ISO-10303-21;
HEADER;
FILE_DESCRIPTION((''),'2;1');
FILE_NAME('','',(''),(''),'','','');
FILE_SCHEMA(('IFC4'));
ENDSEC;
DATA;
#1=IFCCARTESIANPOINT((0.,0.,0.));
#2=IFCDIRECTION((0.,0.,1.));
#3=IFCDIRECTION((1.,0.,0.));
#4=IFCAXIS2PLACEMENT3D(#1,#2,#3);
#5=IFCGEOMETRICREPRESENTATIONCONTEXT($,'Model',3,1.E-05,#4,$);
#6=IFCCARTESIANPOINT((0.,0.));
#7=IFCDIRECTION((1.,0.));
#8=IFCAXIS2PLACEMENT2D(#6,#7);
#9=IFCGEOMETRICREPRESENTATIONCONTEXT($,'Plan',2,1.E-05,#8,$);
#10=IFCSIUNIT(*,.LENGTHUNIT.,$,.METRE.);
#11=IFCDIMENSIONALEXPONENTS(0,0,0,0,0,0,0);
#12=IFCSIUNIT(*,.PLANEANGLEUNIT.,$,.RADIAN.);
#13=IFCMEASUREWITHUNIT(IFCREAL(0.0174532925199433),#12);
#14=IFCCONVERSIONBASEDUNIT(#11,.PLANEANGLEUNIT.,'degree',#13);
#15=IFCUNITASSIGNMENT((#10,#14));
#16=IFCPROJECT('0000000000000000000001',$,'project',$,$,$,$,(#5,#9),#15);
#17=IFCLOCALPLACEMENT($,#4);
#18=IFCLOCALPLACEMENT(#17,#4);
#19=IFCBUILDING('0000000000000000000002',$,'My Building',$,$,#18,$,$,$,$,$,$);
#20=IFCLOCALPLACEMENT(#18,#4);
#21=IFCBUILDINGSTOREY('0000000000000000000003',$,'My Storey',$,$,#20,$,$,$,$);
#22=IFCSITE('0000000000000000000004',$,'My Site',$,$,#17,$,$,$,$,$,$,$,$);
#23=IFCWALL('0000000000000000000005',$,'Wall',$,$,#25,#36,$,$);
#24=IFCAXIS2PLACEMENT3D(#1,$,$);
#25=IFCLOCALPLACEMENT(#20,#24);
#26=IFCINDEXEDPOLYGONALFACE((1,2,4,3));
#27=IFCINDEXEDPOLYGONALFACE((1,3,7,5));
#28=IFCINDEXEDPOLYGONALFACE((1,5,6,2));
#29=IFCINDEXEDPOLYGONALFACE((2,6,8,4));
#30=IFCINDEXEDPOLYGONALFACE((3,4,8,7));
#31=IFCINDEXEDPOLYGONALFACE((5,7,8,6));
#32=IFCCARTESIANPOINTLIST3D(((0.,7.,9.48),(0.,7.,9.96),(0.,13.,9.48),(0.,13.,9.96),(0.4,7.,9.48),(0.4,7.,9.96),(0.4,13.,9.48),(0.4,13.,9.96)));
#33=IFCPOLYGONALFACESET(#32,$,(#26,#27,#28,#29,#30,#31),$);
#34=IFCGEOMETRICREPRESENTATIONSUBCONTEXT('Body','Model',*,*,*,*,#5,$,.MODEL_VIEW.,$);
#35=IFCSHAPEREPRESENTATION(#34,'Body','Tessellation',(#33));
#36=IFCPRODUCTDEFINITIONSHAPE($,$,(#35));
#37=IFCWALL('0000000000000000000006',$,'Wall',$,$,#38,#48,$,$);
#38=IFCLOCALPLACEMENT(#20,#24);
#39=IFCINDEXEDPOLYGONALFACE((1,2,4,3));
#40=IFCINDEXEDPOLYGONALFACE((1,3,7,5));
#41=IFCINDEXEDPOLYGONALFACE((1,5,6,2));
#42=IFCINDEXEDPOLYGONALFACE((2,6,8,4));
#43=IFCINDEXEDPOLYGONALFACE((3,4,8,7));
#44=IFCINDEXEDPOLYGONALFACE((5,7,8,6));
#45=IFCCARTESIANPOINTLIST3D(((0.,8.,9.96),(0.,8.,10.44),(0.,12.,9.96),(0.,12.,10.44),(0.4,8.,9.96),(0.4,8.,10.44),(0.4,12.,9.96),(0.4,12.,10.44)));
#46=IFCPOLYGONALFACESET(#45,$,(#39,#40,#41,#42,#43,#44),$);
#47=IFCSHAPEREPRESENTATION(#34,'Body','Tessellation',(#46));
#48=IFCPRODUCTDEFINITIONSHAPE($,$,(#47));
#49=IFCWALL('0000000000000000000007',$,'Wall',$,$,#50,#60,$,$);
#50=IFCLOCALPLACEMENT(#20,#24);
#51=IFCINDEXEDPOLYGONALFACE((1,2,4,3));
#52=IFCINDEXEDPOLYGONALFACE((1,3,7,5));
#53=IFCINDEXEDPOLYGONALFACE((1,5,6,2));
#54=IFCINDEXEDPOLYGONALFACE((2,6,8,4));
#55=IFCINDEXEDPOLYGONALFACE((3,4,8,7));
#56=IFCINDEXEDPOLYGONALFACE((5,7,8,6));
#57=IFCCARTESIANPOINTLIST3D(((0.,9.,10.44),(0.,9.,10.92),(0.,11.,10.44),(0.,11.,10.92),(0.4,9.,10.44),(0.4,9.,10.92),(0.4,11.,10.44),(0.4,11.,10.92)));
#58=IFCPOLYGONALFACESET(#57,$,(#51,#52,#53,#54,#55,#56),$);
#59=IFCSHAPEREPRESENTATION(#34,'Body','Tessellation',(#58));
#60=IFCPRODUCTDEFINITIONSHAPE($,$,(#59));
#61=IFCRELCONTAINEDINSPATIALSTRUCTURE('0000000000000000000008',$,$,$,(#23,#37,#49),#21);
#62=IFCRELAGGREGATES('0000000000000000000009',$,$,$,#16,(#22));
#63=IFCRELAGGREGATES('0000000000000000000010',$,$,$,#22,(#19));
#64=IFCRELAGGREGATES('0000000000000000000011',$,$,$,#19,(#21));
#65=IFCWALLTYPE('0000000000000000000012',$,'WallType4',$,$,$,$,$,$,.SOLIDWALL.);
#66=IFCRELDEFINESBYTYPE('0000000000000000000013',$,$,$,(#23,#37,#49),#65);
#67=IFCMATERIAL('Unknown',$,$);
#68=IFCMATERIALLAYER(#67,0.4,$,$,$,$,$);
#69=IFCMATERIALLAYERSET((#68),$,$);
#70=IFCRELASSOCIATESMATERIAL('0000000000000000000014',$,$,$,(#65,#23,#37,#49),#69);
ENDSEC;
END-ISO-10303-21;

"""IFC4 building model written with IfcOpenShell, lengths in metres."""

from ifc_helpers import new_model, entity, si_unit, converted_unit, frame, origin_with_axes, origin_2d_with_axis, place, context, subcontext, project, spatial, indexed_curve, outline, extrude, material, layer, layer_set, layer_usage, type_object, element, save


model = new_model("IFC4")

# Units and contexts
model_context = context("Model", 3, precision=1e-05, world=origin_with_axes())
plan_context = context("Plan", 2, precision=1e-05, world=origin_2d_with_axis())
body_context_1 = subcontext(model_context, "Body", "Model", "MODEL_VIEW")
ifc_project = project(units=[si_unit("LENGTHUNIT", "METRE"), converted_unit("PLANEANGLEUNIT", "degree", entity("IfcReal", 0.0174532925199433), si_unit("PLANEANGLEUNIT", "RADIAN"), dimensions=[0, 0, 0, 0, 0, 0, 0])], contexts=[model_context, plan_context])

# Site, building, storey
site_placement = place(None, origin_with_axes())
site = spatial("IfcSite", under=ifc_project, at=site_placement, Name="My Site")
building_placement = place(site_placement, origin_with_axes())
building = spatial("IfcBuilding", under=site, at=building_placement, Name="My Building")
storey_placement = place(building_placement, origin_with_axes())
storey = spatial("IfcBuildingStorey", under=building, at=storey_placement, Name="My Storey")

# Shared definitions
ifc_material = material(Name="Unknown")
ifc_layer = layer(ifc_material, 0.4)
ifc_layer_set = layer_set([ifc_layer])
wall_type = type_object("IfcWallType", Name="WallType4", PredefinedType="SOLIDWALL", material=ifc_layer_set)

# Walls
ifc_layer_usage_1 = layer_usage(ifc_layer_set, "AXIS2", "POSITIVE", 0.0)
wall_1_placement = place(storey_placement, frame((0.4, 7.0, 9.48), z_axis=(0.0, 0.0, 1.0), x_axis=(0.0, 1.0, 0.0)))
element("IfcWall", 1, at=wall_1_placement, inside=storey, type_object=wall_type, material=ifc_layer_usage_1, Name="Wall", context=body_context_1, shape_type="SweptSolid", body=[
    extrude(outline(indexed_curve([(0.0, 0.0), (0.0, 0.4), (6.0, 0.4), (6.0, 0.0), (0.0, 0.0)], self_intersect=False)), origin_with_axes(), (0.0, 0.0, 1.0), 0.48),
])
ifc_layer_usage_2 = layer_usage(ifc_layer_set, "AXIS2", "POSITIVE", 0.0)
wall_2_placement = place(storey_placement, frame((0.4, 8.0, 9.96), z_axis=(0.0, 0.0, 1.0), x_axis=(0.0, 1.0, 0.0)))
element("IfcWall", 2, at=wall_2_placement, inside=storey, type_object=wall_type, material=ifc_layer_usage_2, Name="Wall", context=body_context_1, shape_type="SweptSolid", body=[
    extrude(outline(indexed_curve([(0.0, 0.0), (0.0, 0.4), (4.0, 0.4), (4.0, 0.0), (0.0, 0.0)], self_intersect=False)), origin_with_axes(), (0.0, 0.0, 1.0), 0.48),
])
ifc_layer_usage_3 = layer_usage(ifc_layer_set, "AXIS2", "POSITIVE", 0.0)
wall_3_placement = place(storey_placement, frame((0.4, 9.0, 10.44), z_axis=(0.0, 0.0, 1.0), x_axis=(0.0, 1.0, 0.0)))
element("IfcWall", 3, at=wall_3_placement, inside=storey, type_object=wall_type, material=ifc_layer_usage_3, Name="Wall", context=body_context_1, shape_type="SweptSolid", body=[
    extrude(outline(indexed_curve([(0.0, 0.0), (0.0, 0.4), (2.0, 0.4), (2.0, 0.0), (0.0, 0.0)], self_intersect=False)), origin_with_axes(), (0.0, 0.0, 1.0), 0.48),
])

save(model, "model.ifc")
